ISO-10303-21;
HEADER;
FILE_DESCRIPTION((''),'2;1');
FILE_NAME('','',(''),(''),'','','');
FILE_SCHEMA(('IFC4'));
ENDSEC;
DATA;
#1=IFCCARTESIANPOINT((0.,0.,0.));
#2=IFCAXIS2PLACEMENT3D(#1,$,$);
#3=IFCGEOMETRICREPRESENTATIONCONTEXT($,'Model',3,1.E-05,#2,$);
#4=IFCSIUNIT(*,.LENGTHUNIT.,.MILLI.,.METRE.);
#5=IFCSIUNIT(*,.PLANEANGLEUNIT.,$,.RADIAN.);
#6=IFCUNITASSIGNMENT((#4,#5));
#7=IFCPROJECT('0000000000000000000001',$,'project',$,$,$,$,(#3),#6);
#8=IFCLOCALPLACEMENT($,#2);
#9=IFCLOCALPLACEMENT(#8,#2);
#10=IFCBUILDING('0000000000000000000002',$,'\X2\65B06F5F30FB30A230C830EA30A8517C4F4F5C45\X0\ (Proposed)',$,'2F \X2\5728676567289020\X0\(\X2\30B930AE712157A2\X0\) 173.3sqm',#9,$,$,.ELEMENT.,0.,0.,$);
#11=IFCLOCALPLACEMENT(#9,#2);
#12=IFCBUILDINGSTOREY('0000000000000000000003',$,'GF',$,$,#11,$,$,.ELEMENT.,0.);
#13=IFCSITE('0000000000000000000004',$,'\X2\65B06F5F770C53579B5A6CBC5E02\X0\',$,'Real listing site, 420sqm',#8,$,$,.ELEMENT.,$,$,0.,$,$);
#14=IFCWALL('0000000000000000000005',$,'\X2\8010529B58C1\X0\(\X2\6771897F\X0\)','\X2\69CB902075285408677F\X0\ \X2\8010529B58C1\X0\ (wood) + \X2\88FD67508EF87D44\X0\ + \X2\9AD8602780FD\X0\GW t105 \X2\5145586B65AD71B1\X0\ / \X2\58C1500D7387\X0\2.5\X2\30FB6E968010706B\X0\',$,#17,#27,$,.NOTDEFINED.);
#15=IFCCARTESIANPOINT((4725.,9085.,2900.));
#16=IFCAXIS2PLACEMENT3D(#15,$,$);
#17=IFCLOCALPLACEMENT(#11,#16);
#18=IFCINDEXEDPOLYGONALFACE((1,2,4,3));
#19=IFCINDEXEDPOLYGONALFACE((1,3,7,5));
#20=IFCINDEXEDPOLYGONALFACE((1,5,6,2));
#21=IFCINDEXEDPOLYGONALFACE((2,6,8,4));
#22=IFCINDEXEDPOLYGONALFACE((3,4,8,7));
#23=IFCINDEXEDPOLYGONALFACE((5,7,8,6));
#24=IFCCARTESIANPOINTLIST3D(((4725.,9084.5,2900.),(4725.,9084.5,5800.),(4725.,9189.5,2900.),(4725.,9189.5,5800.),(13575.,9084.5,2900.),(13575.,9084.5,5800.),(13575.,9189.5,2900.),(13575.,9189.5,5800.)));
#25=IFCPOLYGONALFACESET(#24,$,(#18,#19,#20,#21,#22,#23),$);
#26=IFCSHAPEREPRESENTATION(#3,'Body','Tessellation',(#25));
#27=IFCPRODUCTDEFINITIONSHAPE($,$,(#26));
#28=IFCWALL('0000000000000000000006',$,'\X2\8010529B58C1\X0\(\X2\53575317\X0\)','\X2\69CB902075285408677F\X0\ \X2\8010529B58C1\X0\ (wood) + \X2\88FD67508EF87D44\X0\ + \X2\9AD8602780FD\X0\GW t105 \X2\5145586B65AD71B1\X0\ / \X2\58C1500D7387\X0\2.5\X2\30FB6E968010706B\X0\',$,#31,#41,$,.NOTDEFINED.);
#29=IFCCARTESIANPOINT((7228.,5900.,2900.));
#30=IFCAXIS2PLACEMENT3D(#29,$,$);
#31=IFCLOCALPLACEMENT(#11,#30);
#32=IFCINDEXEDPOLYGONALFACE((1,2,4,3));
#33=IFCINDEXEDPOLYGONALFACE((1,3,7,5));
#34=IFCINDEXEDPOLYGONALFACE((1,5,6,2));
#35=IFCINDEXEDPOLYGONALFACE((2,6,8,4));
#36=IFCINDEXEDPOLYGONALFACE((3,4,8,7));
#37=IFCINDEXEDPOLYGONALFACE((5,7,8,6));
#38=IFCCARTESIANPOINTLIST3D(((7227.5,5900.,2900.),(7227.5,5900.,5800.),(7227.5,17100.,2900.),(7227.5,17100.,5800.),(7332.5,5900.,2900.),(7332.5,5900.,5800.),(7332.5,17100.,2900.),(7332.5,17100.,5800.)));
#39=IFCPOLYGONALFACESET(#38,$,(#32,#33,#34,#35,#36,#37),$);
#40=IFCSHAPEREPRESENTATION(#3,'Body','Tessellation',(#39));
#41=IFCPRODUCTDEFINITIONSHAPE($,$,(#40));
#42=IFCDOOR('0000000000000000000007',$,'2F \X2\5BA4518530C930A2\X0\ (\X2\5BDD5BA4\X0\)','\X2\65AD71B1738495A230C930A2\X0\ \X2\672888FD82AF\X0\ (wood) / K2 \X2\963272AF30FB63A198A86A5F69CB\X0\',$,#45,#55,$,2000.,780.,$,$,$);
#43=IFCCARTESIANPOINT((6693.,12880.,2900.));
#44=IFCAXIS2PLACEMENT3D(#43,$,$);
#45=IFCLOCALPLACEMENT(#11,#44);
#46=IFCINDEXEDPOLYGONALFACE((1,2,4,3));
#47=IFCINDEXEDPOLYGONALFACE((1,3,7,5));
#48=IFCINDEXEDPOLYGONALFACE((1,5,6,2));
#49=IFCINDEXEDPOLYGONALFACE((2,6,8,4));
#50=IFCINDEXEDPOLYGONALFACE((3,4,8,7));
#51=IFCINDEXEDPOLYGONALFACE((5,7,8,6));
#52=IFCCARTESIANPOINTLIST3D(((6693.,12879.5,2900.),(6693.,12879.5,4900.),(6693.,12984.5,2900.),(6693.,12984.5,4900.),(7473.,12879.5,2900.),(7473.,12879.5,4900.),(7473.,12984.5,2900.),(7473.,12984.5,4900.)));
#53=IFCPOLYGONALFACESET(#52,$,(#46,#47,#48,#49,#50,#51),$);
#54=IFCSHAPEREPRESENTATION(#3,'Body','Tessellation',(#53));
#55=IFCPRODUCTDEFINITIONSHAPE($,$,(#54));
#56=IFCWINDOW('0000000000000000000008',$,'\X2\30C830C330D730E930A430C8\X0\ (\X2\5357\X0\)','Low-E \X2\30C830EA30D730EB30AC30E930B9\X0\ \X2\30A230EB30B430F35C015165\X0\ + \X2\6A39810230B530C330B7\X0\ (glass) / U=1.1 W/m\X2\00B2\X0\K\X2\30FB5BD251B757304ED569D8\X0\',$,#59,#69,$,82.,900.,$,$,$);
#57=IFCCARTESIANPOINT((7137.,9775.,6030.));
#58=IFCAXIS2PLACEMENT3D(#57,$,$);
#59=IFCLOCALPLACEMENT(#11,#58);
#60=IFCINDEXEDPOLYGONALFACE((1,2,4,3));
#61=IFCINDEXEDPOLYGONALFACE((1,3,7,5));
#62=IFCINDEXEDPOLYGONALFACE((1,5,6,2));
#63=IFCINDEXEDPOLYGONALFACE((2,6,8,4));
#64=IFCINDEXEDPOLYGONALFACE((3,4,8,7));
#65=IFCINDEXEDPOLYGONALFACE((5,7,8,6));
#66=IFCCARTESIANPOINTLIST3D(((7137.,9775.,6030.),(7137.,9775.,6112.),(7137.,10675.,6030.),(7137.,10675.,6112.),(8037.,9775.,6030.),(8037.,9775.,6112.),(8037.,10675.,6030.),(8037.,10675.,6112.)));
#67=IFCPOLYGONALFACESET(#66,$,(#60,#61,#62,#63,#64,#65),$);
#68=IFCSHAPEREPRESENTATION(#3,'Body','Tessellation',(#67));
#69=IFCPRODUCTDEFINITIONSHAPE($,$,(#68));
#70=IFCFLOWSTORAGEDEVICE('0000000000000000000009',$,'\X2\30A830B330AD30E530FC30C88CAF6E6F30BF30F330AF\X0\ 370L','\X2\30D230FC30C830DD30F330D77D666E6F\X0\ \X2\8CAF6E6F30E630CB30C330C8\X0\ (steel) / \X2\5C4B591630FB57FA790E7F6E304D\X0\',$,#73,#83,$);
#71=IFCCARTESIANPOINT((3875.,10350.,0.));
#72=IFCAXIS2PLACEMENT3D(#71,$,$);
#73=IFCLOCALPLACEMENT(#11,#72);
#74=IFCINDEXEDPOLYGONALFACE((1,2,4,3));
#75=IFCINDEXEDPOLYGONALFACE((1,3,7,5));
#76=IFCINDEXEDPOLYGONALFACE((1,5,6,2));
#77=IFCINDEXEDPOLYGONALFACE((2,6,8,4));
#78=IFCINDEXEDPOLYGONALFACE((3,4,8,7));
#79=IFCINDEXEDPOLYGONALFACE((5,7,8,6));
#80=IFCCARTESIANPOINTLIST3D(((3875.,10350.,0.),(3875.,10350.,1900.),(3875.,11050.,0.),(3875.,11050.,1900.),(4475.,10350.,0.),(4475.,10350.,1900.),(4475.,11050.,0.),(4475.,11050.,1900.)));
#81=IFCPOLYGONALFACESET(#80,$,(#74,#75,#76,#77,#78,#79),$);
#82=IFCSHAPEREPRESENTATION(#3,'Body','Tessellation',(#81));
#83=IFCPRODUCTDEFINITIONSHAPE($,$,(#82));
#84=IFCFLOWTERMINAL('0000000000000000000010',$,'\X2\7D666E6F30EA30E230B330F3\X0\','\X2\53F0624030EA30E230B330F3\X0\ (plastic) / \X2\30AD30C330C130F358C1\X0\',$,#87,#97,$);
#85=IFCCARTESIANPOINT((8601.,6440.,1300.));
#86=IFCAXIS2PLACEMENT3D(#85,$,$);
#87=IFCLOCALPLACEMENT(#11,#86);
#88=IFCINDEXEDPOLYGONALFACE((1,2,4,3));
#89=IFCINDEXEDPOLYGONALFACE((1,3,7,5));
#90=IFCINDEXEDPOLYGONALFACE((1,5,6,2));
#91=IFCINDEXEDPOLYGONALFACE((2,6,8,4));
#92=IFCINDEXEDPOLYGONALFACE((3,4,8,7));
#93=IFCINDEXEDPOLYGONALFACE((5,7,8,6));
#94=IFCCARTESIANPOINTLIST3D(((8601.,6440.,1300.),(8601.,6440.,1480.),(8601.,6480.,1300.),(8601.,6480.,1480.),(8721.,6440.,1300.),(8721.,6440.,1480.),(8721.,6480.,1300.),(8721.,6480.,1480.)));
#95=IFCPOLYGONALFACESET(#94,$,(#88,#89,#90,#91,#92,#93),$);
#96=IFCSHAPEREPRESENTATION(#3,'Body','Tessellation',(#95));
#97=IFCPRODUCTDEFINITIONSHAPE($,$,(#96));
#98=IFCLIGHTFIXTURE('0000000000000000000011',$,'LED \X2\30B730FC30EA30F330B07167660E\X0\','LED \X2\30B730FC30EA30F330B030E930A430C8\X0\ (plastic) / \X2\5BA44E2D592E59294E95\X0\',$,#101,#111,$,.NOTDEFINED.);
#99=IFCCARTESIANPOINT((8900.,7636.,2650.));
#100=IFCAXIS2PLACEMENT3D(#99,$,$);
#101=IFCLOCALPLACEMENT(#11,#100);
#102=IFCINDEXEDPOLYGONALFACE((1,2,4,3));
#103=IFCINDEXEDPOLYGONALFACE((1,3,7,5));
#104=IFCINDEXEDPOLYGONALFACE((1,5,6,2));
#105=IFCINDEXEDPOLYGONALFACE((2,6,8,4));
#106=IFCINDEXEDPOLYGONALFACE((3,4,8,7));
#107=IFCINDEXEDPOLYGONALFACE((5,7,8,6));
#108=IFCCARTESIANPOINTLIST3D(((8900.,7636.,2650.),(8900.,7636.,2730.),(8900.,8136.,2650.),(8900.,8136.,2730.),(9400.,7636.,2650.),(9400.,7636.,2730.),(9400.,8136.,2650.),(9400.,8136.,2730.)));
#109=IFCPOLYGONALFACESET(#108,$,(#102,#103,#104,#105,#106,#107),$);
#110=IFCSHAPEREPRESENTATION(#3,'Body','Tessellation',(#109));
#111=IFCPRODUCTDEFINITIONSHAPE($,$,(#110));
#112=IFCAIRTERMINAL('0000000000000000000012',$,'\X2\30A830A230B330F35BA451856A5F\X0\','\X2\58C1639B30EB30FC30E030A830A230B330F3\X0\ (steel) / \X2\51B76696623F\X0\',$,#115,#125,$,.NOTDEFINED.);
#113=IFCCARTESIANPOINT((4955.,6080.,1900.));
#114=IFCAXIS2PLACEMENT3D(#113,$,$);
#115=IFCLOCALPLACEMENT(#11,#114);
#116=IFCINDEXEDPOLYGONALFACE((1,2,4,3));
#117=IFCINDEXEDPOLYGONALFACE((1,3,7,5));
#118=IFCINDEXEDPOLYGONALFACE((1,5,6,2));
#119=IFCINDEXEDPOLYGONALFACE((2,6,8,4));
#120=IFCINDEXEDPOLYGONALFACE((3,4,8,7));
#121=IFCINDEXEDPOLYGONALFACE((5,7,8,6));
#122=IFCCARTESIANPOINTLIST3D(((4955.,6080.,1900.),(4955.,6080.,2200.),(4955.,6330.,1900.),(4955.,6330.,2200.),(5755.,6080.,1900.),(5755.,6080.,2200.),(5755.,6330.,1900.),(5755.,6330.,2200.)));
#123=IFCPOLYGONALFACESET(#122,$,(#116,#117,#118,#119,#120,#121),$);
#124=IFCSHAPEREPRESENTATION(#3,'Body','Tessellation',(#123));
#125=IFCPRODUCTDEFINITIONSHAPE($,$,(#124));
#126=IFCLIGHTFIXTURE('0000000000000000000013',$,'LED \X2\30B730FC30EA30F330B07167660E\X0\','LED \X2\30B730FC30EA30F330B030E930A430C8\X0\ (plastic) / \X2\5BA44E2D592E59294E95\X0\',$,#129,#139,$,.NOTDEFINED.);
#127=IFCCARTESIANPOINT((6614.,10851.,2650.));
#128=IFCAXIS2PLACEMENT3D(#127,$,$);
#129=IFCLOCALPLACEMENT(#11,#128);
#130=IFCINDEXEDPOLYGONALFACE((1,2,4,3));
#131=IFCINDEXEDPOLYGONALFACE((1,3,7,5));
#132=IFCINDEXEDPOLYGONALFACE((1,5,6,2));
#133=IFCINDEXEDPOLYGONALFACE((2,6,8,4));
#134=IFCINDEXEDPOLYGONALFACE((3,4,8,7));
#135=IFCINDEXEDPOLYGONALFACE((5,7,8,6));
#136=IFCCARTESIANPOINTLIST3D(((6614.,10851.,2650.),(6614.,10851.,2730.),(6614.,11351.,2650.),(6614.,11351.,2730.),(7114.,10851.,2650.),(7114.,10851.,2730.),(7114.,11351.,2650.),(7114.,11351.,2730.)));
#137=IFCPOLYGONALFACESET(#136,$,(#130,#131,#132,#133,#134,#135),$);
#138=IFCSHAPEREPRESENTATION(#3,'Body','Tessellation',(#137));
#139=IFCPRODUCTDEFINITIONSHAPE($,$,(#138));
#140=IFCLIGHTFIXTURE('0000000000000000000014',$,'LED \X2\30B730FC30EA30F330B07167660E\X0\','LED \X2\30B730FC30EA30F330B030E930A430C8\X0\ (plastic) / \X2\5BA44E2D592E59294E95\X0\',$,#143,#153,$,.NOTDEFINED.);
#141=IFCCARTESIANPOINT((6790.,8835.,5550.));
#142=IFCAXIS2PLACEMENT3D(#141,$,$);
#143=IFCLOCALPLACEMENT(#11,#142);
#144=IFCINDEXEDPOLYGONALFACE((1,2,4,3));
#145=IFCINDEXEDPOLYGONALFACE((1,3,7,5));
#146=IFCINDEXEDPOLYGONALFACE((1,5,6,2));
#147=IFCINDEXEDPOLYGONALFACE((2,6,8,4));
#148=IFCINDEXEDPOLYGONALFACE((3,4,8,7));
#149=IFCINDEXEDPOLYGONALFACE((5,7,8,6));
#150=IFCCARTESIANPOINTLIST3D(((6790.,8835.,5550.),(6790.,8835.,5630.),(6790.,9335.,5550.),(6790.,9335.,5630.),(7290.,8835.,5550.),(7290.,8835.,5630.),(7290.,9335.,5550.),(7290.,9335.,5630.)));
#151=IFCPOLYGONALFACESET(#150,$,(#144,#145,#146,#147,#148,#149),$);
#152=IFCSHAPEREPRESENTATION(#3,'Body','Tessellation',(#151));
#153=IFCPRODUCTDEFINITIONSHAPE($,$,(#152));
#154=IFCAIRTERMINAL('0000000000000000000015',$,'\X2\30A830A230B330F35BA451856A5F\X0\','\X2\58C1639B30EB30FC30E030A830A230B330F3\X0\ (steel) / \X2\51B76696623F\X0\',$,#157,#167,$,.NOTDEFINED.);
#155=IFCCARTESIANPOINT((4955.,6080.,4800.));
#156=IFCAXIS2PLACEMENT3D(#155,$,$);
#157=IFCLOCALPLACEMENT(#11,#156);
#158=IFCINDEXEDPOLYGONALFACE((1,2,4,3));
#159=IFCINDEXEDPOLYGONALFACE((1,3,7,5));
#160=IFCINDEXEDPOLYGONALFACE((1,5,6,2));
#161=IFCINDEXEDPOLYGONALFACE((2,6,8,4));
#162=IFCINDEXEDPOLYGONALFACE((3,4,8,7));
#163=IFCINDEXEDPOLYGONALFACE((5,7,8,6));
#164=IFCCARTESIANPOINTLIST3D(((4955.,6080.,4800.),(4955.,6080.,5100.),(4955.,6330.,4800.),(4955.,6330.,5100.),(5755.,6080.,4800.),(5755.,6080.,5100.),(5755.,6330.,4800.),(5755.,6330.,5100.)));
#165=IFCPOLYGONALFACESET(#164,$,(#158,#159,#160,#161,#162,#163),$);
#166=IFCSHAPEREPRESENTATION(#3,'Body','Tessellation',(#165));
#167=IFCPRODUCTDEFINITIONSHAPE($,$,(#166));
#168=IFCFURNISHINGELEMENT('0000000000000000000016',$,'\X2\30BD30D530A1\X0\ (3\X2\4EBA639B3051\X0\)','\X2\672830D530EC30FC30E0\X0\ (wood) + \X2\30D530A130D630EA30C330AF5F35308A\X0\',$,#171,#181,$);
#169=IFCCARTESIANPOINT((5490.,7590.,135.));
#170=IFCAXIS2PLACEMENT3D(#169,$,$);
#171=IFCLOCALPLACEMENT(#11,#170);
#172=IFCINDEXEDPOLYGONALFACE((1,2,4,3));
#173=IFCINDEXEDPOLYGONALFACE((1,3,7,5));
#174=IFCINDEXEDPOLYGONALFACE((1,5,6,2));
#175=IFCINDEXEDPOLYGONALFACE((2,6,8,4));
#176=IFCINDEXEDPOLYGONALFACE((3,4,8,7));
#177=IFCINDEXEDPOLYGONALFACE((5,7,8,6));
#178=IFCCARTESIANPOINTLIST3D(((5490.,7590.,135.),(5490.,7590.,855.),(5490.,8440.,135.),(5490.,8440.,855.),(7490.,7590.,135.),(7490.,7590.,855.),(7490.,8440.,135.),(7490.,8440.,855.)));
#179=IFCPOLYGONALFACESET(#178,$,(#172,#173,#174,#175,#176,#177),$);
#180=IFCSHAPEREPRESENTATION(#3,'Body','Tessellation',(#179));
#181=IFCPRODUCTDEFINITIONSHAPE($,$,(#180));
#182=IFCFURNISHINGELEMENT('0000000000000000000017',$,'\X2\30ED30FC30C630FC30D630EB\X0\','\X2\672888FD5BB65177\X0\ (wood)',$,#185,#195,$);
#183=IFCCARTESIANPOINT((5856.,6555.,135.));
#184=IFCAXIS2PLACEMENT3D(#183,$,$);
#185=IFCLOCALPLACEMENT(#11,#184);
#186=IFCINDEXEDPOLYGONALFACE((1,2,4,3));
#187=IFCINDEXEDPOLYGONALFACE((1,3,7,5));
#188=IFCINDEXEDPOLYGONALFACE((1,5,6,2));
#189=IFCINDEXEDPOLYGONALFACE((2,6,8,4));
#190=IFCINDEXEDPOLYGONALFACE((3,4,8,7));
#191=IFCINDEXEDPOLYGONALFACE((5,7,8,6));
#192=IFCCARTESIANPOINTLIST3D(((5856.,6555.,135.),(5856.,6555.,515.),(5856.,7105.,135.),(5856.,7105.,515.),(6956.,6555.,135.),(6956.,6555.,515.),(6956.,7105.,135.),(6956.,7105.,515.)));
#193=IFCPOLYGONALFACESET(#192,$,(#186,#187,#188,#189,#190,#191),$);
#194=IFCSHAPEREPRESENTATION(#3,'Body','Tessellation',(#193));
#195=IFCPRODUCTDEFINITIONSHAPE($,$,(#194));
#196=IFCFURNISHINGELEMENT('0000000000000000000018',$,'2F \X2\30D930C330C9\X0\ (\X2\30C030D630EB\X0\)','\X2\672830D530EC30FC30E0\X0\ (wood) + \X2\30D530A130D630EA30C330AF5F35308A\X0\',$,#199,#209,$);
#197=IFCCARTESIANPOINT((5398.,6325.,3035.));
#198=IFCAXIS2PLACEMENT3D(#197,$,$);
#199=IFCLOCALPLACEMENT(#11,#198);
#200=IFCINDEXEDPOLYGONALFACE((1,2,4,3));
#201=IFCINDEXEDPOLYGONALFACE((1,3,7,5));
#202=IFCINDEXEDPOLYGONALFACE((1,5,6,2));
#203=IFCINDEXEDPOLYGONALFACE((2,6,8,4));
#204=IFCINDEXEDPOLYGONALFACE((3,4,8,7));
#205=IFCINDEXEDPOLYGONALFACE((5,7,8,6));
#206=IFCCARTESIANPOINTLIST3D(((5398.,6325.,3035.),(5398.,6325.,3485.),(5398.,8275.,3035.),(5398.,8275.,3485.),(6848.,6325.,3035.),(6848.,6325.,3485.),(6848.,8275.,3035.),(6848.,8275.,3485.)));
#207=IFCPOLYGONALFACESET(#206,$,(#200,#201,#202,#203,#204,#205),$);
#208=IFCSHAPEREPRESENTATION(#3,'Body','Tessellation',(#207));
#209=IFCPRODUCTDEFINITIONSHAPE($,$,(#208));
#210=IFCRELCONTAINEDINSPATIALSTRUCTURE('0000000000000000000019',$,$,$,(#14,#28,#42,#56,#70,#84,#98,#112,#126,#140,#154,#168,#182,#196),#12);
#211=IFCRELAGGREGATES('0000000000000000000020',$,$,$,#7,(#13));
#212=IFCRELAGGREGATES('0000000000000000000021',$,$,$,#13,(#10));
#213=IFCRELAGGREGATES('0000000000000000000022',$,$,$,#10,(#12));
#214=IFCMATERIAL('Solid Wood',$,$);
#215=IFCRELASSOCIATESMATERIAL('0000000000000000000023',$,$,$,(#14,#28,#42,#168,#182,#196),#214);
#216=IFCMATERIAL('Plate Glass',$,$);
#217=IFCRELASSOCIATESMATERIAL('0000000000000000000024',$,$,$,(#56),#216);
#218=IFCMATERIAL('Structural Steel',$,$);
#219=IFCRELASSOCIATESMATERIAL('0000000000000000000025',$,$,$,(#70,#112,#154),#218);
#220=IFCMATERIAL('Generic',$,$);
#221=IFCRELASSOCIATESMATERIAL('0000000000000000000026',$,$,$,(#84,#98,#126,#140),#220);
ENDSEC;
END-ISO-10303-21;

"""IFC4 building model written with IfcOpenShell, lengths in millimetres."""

from ifc_helpers import new_model, si_unit, frame, frame_2d, origin, place, context, project, spatial, rectangle, extrude, material, element, fill, save


model = new_model("IFC4")

# Units and contexts
model_context = context("Model", 3, precision=1e-05, world=origin())
ifc_project = project(units=[si_unit("LENGTHUNIT", "METRE", prefix="MILLI"), si_unit("PLANEANGLEUNIT", "RADIAN")], contexts=[model_context])

# Site, building, storey
site_placement = place(None, origin())
site = spatial("IfcSite", under=ifc_project, at=site_placement, Name="新潟県南魚沼市", ObjectType="Real listing site, 420sqm", CompositionType="ELEMENT", RefElevation=0.0)
building_placement = place(site_placement, origin())
building = spatial("IfcBuilding", under=site, at=building_placement, Name="新潟・アトリエ兼住居 (Proposed)", ObjectType="2F 在来木造(スギ無垢) 173.3sqm", CompositionType="ELEMENT", ElevationOfRefHeight=0.0, ElevationOfTerrain=0.0)
storey_placement = place(building_placement, origin())
storey = spatial("IfcBuildingStorey", under=building, at=storey_placement, Name="GF", CompositionType="ELEMENT", Elevation=0.0)

# Shared definitions
ifc_material_1 = material(Name="Solid Wood")

# Wall
wall_1_placement = place(storey_placement, frame((4725.0, 9085.0, 2900.0)))
element("IfcWall", 1, at=wall_1_placement, inside=storey, material=ifc_material_1, Name="耐力壁(東西)", Description="構造用合板 耐力壁 (wood) + 製材軸組 + 高性能GW t105 充填断熱 / 壁倍率2.5・準耐火", PredefinedType="NOTDEFINED", context=model_context, shape_type="SweptSolid", body=[
    extrude(rectangle(XDim=8850.0, YDim=105.0, at=frame_2d((4425.0, 52.0))), frame((4725.0, 9085.0, 2900.0)), (0.0, 0.0, 1.0), 2900.0),
])

# Wall, opening, door
wall_2_placement = place(storey_placement, frame((7228.0, 5900.0, 2900.0)))
wall_2 = element("IfcWall", 2, at=wall_2_placement, inside=storey, material=ifc_material_1, Name="耐力壁(南北)", Description="構造用合板 耐力壁 (wood) + 製材軸組 + 高性能GW t105 充填断熱 / 壁倍率2.5・準耐火", PredefinedType="NOTDEFINED", context=model_context, shape_type="SweptSolid", body=[
    extrude(rectangle(XDim=105.0, YDim=11200.0, at=frame_2d((52.0, 5600.0))), frame((7228.0, 5900.0, 2900.0)), (0.0, 0.0, 1.0), 2900.0),
])
opening_placement = place(storey_placement, frame((6693.0, 12880.0, 2900.0)))
opening = element("IfcOpeningElement", 3, at=opening_placement, cuts=wall_2, PredefinedType="NOTDEFINED", context=model_context, shape_type="SweptSolid", body=[
    extrude(rectangle(XDim=780.0, YDim=105.0, at=frame_2d((390.0, 52.0))), frame((6693.0, 12880.0, 2900.0)), (0.0, 0.0, 1.0), 2000.0),
])
door_placement = place(storey_placement, frame((6693.0, 12880.0, 2900.0)))
door = element("IfcDoor", 4, at=door_placement, inside=storey, material=ifc_material_1, Name="2F 室内ドア (寝室)", Description="断熱玄関ドア 木製芯 (wood) / K2 防犯・採風機構", OverallHeight=2000.0, OverallWidth=780.0, context=model_context, shape_type="SweptSolid", body=[
    extrude(rectangle(XDim=780.0, YDim=105.0, at=frame_2d((390.0, 52.0))), frame((6693.0, 12880.0, 2900.0)), (0.0, 0.0, 1.0), 2000.0),
])
fill(opening, door)

# Window
ifc_material_2 = material(Name="Plate Glass")
window_placement = place(storey_placement, frame((7137.0, 9775.0, 6030.0)))
element("IfcWindow", 5, at=window_placement, inside=storey, material=ifc_material_2, Name="トップライト (南)", Description="Low-E トリプルガラス アルゴン封入 + 樹脂サッシ (glass) / U=1.1 W/m²K・寒冷地仕様", OverallHeight=82.0, OverallWidth=900.0, context=model_context, shape_type="SweptSolid", body=[
    extrude(rectangle(XDim=900.0, YDim=900.0, at=frame_2d((450.0, 450.0))), frame((7137.0, 9775.0, 6030.0)), (0.0, 0.0, 1.0), 82.0),
])

# Flow storage device
ifc_material_3 = material(Name="Structural Steel")
flow_storage_device_placement = place(storey_placement, frame((3875.0, 10350.0, 0.0)))
element("IfcFlowStorageDevice", 6, at=flow_storage_device_placement, inside=storey, material=ifc_material_3, Name="エコキュート貯湯タンク 370L", Description="ヒートポンプ給湯 貯湯ユニット (steel) / 屋外・基礎置き", context=model_context, shape_type="SweptSolid", body=[
    extrude(rectangle(XDim=600.0, YDim=700.0, at=frame_2d((300.0, 350.0))), frame((3875.0, 10350.0, 0.0)), (0.0, 0.0, 1.0), 1900.0),
])

# Flow terminal
ifc_material_4 = material(Name="Generic")
flow_terminal_placement = place(storey_placement, frame((8601.0, 6440.0, 1300.0)))
element("IfcFlowTerminal", 7, at=flow_terminal_placement, inside=storey, material=ifc_material_4, Name="給湯リモコン", Description="台所リモコン (plastic) / キッチン壁", context=model_context, shape_type="SweptSolid", body=[
    extrude(rectangle(XDim=120.0, YDim=40.0, at=frame_2d((60.0, 20.0))), frame((8601.0, 6440.0, 1300.0)), (0.0, 0.0, 1.0), 180.0),
])

# Light fixture
light_fixture_1_placement = place(storey_placement, frame((8900.0, 7636.0, 2650.0)))
element("IfcLightFixture", 8, at=light_fixture_1_placement, inside=storey, material=ifc_material_4, Name="LED シーリング照明", Description="LED シーリングライト (plastic) / 室中央天井", PredefinedType="NOTDEFINED", context=model_context, shape_type="SweptSolid", body=[
    extrude(rectangle(XDim=500.0, YDim=500.0, at=frame_2d((250.0, 250.0))), frame((8900.0, 7636.0, 2650.0)), (0.0, 0.0, 1.0), 80.0),
])

# Air terminal
air_terminal_1_placement = place(storey_placement, frame((4955.0, 6080.0, 1900.0)))
element("IfcAirTerminal", 9, at=air_terminal_1_placement, inside=storey, material=ifc_material_3, Name="エアコン室内機", Description="壁掛ルームエアコン (steel) / 冷暖房", PredefinedType="NOTDEFINED", context=model_context, shape_type="SweptSolid", body=[
    extrude(rectangle(XDim=800.0, YDim=250.0, at=frame_2d((400.0, 125.0))), frame((4955.0, 6080.0, 1900.0)), (0.0, 0.0, 1.0), 300.0),
])

# Light fixtures
light_fixture_2_placement = place(storey_placement, frame((6614.0, 10851.0, 2650.0)))
element("IfcLightFixture", 10, at=light_fixture_2_placement, inside=storey, material=ifc_material_4, Name="LED シーリング照明", Description="LED シーリングライト (plastic) / 室中央天井", PredefinedType="NOTDEFINED", context=model_context, shape_type="SweptSolid", body=[
    extrude(rectangle(XDim=500.0, YDim=500.0, at=frame_2d((250.0, 250.0))), frame((6614.0, 10851.0, 2650.0)), (0.0, 0.0, 1.0), 80.0),
])
light_fixture_3_placement = place(storey_placement, frame((6790.0, 8835.0, 5550.0)))
element("IfcLightFixture", 11, at=light_fixture_3_placement, inside=storey, material=ifc_material_4, Name="LED シーリング照明", Description="LED シーリングライト (plastic) / 室中央天井", PredefinedType="NOTDEFINED", context=model_context, shape_type="SweptSolid", body=[
    extrude(rectangle(XDim=500.0, YDim=500.0, at=frame_2d((250.0, 250.0))), frame((6790.0, 8835.0, 5550.0)), (0.0, 0.0, 1.0), 80.0),
])

# Air terminal
air_terminal_2_placement = place(storey_placement, frame((4955.0, 6080.0, 4800.0)))
element("IfcAirTerminal", 12, at=air_terminal_2_placement, inside=storey, material=ifc_material_3, Name="エアコン室内機", Description="壁掛ルームエアコン (steel) / 冷暖房", PredefinedType="NOTDEFINED", context=model_context, shape_type="SweptSolid", body=[
    extrude(rectangle(XDim=800.0, YDim=250.0, at=frame_2d((400.0, 125.0))), frame((4955.0, 6080.0, 4800.0)), (0.0, 0.0, 1.0), 300.0),
])

# Furnishing elements
furnishing_1_placement = place(storey_placement, frame((5490.0, 7590.0, 135.0)))
element("IfcFurnishingElement", 13, at=furnishing_1_placement, inside=storey, material=ifc_material_1, Name="ソファ (3人掛け)", Description="木フレーム (wood) + ファブリック張り", context=model_context, shape_type="SweptSolid", body=[
    extrude(rectangle(XDim=2000.0, YDim=850.0, at=frame_2d((1000.0, 425.0))), frame((5490.0, 7590.0, 135.0)), (0.0, 0.0, 1.0), 720.0),
])
furnishing_2_placement = place(storey_placement, frame((5856.0, 6555.0, 135.0)))
element("IfcFurnishingElement", 14, at=furnishing_2_placement, inside=storey, material=ifc_material_1, Name="ローテーブル", Description="木製家具 (wood)", context=model_context, shape_type="SweptSolid", body=[
    extrude(rectangle(XDim=1100.0, YDim=550.0, at=frame_2d((550.0, 275.0))), frame((5856.0, 6555.0, 135.0)), (0.0, 0.0, 1.0), 380.0),
])
furnishing_3_placement = place(storey_placement, frame((5398.0, 6325.0, 3035.0)))
element("IfcFurnishingElement", 15, at=furnishing_3_placement, inside=storey, material=ifc_material_1, Name="2F ベッド (ダブル)", Description="木フレーム (wood) + ファブリック張り", context=model_context, shape_type="SweptSolid", body=[
    extrude(rectangle(XDim=1450.0, YDim=1950.0, at=frame_2d((725.0, 975.0))), frame((5398.0, 6325.0, 3035.0)), (0.0, 0.0, 1.0), 450.0),
])

save(model, "model.ifc")
